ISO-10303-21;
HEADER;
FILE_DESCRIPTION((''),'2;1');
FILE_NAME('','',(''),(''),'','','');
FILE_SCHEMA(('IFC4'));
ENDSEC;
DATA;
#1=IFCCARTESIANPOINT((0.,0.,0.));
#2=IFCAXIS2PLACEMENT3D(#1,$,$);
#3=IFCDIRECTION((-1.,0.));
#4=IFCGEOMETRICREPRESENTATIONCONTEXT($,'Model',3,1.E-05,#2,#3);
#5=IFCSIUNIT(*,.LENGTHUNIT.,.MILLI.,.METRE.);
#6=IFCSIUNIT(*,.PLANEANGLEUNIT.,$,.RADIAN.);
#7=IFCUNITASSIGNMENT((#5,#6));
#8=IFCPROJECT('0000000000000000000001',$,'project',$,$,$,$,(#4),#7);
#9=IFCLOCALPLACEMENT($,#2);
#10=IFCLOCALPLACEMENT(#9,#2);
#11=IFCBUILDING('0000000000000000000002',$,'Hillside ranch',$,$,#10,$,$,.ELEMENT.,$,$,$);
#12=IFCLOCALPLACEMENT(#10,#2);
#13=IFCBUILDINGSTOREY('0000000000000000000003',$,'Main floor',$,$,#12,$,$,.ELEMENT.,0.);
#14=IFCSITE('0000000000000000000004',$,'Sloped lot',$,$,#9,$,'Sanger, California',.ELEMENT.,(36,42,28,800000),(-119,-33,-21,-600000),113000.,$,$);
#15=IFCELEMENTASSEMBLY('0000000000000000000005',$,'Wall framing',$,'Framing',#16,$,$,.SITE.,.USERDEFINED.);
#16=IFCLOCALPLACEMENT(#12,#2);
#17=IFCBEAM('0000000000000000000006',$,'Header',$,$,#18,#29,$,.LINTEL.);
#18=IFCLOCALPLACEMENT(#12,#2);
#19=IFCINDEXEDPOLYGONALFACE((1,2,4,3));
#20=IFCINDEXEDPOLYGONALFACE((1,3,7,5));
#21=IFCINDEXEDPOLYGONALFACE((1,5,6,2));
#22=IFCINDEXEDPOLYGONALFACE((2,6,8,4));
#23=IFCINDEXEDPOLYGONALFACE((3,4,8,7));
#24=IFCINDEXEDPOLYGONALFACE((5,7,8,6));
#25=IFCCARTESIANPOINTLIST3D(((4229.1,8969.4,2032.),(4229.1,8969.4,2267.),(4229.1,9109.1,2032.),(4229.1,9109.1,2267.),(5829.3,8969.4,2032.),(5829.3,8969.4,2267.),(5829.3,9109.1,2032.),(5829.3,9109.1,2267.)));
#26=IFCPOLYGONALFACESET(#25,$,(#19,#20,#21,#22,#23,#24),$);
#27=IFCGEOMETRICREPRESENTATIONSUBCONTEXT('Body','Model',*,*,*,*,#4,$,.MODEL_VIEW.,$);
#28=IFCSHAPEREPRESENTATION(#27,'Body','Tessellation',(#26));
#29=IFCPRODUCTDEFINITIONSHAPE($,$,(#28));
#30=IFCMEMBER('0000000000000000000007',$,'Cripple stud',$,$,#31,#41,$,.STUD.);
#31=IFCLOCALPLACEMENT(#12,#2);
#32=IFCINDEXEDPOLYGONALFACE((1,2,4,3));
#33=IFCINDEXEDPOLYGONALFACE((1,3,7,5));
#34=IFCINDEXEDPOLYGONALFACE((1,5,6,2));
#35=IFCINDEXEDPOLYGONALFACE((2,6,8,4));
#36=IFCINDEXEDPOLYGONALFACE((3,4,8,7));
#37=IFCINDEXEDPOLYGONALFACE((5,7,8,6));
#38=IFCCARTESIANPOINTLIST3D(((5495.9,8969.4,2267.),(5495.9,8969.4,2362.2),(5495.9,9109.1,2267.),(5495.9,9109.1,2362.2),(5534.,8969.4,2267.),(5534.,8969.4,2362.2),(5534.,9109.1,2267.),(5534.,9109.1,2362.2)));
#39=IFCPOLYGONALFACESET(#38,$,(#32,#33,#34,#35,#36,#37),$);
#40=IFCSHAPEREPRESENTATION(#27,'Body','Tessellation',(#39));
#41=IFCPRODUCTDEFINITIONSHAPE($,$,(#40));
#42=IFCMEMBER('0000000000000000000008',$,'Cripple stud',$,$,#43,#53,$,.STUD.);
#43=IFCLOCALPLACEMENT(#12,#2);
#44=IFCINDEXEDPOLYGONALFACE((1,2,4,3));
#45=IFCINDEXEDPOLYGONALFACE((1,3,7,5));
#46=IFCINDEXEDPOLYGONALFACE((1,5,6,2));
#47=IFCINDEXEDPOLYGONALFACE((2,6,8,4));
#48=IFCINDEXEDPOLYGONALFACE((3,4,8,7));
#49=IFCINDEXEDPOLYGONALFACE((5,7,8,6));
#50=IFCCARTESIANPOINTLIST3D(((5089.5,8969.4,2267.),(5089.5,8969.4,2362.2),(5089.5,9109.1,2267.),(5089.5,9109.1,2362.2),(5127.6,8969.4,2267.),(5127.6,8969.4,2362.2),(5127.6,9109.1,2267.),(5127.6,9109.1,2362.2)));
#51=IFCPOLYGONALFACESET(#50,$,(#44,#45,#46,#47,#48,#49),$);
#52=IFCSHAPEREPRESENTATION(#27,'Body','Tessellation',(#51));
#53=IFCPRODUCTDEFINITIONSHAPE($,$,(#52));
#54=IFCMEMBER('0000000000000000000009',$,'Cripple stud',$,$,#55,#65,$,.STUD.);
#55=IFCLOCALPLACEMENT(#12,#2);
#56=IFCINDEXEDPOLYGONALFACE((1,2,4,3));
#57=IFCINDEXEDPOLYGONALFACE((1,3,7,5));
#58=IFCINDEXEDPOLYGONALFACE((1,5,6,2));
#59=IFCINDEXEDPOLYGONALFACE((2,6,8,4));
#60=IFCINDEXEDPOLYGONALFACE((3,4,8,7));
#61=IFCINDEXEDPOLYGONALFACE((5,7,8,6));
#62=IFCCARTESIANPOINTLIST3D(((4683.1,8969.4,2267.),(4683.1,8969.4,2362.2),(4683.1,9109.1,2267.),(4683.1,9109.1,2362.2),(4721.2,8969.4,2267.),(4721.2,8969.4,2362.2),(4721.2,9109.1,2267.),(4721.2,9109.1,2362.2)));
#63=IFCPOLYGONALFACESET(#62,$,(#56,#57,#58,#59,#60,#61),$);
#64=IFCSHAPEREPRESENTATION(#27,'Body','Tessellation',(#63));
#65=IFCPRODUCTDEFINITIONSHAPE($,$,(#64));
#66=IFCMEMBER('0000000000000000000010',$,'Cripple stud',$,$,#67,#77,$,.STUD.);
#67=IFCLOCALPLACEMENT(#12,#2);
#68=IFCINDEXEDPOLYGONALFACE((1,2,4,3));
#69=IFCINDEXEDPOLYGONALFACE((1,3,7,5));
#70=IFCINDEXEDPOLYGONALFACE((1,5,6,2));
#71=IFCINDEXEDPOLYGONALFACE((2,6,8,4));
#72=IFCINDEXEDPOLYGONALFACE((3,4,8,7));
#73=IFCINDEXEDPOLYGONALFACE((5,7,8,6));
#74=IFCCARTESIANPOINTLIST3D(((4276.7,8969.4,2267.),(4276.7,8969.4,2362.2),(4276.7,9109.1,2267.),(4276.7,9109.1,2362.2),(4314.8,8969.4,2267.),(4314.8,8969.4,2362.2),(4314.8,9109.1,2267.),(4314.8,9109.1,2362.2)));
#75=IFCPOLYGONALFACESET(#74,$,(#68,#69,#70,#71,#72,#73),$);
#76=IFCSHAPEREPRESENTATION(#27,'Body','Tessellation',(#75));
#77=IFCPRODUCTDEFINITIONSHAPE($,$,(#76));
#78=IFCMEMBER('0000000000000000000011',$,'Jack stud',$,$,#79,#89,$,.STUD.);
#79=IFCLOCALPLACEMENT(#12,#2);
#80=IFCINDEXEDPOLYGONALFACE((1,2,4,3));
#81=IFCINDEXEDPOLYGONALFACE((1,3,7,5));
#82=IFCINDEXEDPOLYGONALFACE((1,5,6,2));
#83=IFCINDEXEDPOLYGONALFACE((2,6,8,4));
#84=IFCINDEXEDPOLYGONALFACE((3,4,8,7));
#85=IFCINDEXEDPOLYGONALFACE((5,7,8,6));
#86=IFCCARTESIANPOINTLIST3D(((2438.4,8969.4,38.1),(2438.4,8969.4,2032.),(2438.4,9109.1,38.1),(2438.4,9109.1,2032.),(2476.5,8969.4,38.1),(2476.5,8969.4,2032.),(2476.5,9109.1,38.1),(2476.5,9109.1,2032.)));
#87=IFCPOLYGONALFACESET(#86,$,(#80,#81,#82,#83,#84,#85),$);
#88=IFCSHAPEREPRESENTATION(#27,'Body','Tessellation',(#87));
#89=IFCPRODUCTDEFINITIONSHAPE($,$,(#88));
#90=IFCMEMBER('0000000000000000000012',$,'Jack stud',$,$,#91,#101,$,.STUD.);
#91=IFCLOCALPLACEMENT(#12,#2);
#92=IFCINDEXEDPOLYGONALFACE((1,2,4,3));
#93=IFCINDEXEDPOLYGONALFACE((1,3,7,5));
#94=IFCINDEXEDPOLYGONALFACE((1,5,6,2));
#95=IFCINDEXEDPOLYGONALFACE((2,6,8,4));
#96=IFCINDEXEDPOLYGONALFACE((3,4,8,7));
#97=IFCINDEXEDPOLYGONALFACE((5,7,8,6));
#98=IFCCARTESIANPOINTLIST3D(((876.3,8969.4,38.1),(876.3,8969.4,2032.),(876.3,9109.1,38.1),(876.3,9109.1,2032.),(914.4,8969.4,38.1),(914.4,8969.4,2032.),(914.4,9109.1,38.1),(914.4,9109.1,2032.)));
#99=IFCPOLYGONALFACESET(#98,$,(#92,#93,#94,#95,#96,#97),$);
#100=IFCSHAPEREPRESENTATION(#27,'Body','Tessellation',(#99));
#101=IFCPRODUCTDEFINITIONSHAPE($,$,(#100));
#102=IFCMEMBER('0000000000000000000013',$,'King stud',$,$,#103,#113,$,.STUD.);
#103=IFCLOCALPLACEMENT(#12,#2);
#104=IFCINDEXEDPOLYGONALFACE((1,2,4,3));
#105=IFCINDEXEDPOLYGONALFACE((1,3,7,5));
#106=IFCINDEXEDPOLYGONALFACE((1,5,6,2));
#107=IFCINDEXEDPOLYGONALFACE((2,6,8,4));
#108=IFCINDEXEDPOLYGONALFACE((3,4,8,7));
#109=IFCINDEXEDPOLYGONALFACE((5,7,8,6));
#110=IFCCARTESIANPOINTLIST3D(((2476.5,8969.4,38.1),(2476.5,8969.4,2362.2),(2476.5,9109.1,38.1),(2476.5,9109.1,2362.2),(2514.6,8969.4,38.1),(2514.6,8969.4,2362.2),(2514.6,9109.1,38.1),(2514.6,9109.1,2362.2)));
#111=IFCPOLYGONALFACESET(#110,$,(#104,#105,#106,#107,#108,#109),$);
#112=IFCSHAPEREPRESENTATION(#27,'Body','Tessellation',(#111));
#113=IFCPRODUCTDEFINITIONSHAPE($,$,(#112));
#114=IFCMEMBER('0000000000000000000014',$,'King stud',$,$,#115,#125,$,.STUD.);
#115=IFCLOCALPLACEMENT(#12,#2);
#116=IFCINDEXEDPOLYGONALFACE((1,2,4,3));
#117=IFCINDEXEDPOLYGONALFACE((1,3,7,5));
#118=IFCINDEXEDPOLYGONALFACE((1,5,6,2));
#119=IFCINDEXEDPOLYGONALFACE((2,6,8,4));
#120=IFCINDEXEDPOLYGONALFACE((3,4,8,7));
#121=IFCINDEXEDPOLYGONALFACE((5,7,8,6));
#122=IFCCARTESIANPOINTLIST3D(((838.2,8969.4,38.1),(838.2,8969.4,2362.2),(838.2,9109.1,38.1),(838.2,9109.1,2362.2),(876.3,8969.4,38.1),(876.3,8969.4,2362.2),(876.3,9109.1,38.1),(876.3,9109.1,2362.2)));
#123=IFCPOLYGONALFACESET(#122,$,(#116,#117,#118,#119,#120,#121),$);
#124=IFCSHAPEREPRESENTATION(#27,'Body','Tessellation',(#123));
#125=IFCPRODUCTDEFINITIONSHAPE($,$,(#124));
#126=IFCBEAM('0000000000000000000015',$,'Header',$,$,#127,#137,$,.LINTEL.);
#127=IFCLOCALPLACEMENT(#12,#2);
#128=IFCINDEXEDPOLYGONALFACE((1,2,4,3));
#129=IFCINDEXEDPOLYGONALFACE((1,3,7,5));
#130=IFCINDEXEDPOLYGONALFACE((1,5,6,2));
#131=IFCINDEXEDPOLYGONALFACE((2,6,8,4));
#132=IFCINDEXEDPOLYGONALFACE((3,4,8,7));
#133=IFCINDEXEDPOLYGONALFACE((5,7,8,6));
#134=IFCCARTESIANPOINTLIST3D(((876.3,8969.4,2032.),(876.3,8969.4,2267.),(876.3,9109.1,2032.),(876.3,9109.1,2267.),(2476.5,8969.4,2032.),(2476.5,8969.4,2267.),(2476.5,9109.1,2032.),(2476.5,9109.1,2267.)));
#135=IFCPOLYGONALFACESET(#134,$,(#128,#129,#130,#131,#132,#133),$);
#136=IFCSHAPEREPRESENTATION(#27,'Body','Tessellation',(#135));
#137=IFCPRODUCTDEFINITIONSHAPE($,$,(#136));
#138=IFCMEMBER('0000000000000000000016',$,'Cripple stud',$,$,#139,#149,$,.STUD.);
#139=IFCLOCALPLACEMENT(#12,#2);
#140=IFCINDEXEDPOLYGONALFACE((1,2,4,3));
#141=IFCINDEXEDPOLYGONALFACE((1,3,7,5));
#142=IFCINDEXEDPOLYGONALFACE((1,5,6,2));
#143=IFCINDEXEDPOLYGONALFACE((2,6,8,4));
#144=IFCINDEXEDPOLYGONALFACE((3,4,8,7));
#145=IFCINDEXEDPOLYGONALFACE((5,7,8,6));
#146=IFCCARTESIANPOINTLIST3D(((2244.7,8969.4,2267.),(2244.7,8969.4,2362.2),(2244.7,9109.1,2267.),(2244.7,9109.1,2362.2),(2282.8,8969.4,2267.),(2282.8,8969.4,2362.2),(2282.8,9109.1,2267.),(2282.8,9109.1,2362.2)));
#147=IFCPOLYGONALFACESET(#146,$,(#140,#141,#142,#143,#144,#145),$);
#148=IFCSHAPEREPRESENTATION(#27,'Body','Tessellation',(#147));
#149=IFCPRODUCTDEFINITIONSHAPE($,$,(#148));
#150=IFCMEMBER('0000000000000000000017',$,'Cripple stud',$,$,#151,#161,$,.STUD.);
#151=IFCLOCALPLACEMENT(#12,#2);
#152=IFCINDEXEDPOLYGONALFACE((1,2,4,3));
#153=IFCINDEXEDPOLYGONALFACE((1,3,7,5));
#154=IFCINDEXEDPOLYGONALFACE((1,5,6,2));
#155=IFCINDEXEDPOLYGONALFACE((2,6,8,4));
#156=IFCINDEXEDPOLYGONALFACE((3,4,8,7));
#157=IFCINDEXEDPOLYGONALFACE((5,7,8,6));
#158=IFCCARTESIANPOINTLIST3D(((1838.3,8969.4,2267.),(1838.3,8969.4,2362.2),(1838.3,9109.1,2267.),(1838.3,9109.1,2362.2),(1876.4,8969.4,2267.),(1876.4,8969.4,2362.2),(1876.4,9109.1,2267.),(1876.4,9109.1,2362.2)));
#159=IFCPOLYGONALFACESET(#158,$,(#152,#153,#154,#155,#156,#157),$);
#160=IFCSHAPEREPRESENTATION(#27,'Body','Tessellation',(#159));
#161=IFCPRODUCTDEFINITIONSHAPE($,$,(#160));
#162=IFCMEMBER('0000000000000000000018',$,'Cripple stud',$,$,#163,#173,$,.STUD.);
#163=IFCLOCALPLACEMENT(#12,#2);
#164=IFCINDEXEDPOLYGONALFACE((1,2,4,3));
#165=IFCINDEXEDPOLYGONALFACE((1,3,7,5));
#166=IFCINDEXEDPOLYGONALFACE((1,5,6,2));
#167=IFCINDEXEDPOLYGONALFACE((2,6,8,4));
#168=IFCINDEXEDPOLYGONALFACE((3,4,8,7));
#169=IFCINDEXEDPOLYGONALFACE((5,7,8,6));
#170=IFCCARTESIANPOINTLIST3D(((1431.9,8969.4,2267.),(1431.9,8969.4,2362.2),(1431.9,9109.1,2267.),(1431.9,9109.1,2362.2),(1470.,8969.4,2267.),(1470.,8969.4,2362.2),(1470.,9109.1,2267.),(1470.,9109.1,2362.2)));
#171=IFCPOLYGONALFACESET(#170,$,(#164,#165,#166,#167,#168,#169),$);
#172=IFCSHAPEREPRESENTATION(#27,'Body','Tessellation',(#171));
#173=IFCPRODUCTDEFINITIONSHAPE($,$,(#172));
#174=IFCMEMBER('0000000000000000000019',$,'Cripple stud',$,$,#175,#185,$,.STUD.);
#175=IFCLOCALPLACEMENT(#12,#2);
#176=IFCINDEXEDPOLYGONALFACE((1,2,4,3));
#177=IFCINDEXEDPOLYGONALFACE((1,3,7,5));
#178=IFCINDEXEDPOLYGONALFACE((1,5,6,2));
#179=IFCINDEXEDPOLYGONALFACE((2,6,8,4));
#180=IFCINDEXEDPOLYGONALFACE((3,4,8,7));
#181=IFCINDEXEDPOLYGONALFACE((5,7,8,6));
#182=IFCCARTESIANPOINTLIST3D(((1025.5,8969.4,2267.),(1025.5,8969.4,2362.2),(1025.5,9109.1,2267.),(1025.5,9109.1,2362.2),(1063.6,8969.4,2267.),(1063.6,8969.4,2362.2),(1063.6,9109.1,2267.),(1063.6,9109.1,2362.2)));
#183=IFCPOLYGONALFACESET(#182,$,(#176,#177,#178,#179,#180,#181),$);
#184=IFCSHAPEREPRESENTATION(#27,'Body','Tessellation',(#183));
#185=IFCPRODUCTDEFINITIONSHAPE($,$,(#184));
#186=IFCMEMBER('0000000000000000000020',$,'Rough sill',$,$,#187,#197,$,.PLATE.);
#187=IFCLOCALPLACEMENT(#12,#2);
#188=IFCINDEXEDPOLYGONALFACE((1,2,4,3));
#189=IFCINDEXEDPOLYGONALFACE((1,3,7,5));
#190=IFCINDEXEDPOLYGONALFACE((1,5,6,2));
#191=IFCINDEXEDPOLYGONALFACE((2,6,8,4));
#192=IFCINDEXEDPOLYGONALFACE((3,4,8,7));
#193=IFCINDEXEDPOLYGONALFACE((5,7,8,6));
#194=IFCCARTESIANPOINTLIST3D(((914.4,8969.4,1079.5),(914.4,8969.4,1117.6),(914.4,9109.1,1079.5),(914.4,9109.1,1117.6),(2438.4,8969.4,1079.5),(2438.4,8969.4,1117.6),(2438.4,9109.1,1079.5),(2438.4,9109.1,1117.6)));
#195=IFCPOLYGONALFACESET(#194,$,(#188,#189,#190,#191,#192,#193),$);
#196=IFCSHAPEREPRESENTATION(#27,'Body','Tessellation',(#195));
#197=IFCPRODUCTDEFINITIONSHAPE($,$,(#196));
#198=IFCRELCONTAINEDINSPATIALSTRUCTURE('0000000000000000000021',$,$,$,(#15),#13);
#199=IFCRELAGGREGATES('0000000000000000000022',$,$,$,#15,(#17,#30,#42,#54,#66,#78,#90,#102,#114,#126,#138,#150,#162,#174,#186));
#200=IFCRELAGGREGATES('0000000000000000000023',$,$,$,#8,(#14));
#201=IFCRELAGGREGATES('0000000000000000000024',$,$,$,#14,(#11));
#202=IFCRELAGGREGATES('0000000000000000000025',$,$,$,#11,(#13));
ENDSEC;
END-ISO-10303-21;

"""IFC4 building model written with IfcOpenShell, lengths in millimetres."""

from ifc_helpers import new_model, si_unit, direction, frame, origin, origin_with_axes, place, context, subcontext, project, spatial, polyline, outline, extrude, element, aggregate, save


model = new_model("IFC4")

# Units and contexts
model_context = context("Model", 3, precision=1e-05, world=origin(), true_north=direction((-1.0, 0.0)))
body_context = subcontext(model_context, "Body", "Model", "MODEL_VIEW")
ifc_project = project(units=[si_unit("LENGTHUNIT", "METRE", prefix="MILLI"), si_unit("PLANEANGLEUNIT", "RADIAN")], contexts=[model_context])

# Site, building, storey
site_placement = place(None, origin())
site = spatial("IfcSite", under=ifc_project, at=site_placement, Name="Sloped lot", LongName="Sanger, California", CompositionType="ELEMENT", RefLatitude=(36, 42, 28, 800000), RefLongitude=(-119, -33, -21, -600000), RefElevation=113000.0)
building_placement = place(site_placement, origin())
building = spatial("IfcBuilding", under=site, at=building_placement, Name="Hillside ranch", CompositionType="ELEMENT")
storey_placement = place(building_placement, origin())
storey = spatial("IfcBuildingStorey", under=building, at=storey_placement, Name="Main floor", CompositionType="ELEMENT", Elevation=0.0)

# Element assembly, beams, members
assembly_placement = place(storey_placement, origin_with_axes())
assembly = element("IfcElementAssembly", 1, at=assembly_placement, inside=storey, Name="Wall framing", ObjectType="Framing", AssemblyPlace="SITE", PredefinedType="USERDEFINED")
beam_1_placement = place(storey_placement, origin_with_axes())
beam_1 = element("IfcBeam", 2, at=beam_1_placement, Name="Header", PredefinedType="LINTEL", context=body_context, shape_type="SweptSolid", body=[
    extrude(outline(polyline([(0.0, 0.0), (1600.2, 0.0), (1600.2, 139.7), (0.0, 139.7), (0.0, 0.0)])), frame((5829.3, 9109.1, 2032.0), z_axis=(0.0, 0.0, 1.0), x_axis=(-1.0, 0.0, 0.0)), (0.0, 0.0, 1.0), 234.9),
])
member_1_placement = place(storey_placement, origin_with_axes())
member_1 = element("IfcMember", 3, at=member_1_placement, Name="Cripple stud", PredefinedType="STUD", context=body_context, shape_type="SweptSolid", body=[
    extrude(outline(polyline([(0.0, 0.0), (38.1, 0.0), (38.1, 139.7), (0.0, 139.7), (0.0, 0.0)])), frame((5534.0, 9109.1, 2266.9), z_axis=(0.0, 0.0, 1.0), x_axis=(-1.0, 0.0, 0.0)), (0.0, 0.0, 1.0), 95.2),
])
member_2_placement = place(storey_placement, origin_with_axes())
member_2 = element("IfcMember", 4, at=member_2_placement, Name="Cripple stud", PredefinedType="STUD", context=body_context, shape_type="SweptSolid", body=[
    extrude(outline(polyline([(0.0, 0.0), (38.1, 0.0), (38.1, 139.7), (0.0, 139.7), (0.0, 0.0)])), frame((5127.6, 9109.1, 2266.9), z_axis=(0.0, 0.0, 1.0), x_axis=(-1.0, 0.0, 0.0)), (0.0, 0.0, 1.0), 95.2),
])
member_3_placement = place(storey_placement, origin_with_axes())
member_3 = element("IfcMember", 5, at=member_3_placement, Name="Cripple stud", PredefinedType="STUD", context=body_context, shape_type="SweptSolid", body=[
    extrude(outline(polyline([(0.0, 0.0), (38.1, 0.0), (38.1, 139.7), (0.0, 139.7), (0.0, 0.0)])), frame((4721.2, 9109.1, 2266.9), z_axis=(0.0, 0.0, 1.0), x_axis=(-1.0, 0.0, 0.0)), (0.0, 0.0, 1.0), 95.2),
])
member_4_placement = place(storey_placement, origin_with_axes())
member_4 = element("IfcMember", 6, at=member_4_placement, Name="Cripple stud", PredefinedType="STUD", context=body_context, shape_type="SweptSolid", body=[
    extrude(outline(polyline([(0.0, 0.0), (38.1, 0.0), (38.1, 139.7), (0.0, 139.7), (0.0, 0.0)])), frame((4314.8, 9109.1, 2266.9), z_axis=(0.0, 0.0, 1.0), x_axis=(-1.0, 0.0, 0.0)), (0.0, 0.0, 1.0), 95.2),
])
member_5_placement = place(storey_placement, origin_with_axes())
member_5 = element("IfcMember", 7, at=member_5_placement, Name="Jack stud", PredefinedType="STUD", context=body_context, shape_type="SweptSolid", body=[
    extrude(outline(polyline([(0.0, 0.0), (38.1, 0.0), (38.1, 139.7), (0.0, 139.7), (0.0, 0.0)])), frame((2476.5, 9109.1, 38.1), z_axis=(0.0, 0.0, 1.0), x_axis=(-1.0, 0.0, 0.0)), (0.0, 0.0, 1.0), 1993.9),
])
member_6_placement = place(storey_placement, origin_with_axes())
member_6 = element("IfcMember", 8, at=member_6_placement, Name="Jack stud", PredefinedType="STUD", context=body_context, shape_type="SweptSolid", body=[
    extrude(outline(polyline([(0.0, 0.0), (38.1, 0.0), (38.1, 139.7), (0.0, 139.7), (0.0, 0.0)])), frame((914.4, 9109.1, 38.1), z_axis=(0.0, 0.0, 1.0), x_axis=(-1.0, 0.0, 0.0)), (0.0, 0.0, 1.0), 1993.9),
])
member_7_placement = place(storey_placement, origin_with_axes())
member_7 = element("IfcMember", 9, at=member_7_placement, Name="King stud", PredefinedType="STUD", context=body_context, shape_type="SweptSolid", body=[
    extrude(outline(polyline([(0.0, 0.0), (38.1, 0.0), (38.1, 139.7), (0.0, 139.7), (0.0, 0.0)])), frame((2514.6, 9109.1, 38.1), z_axis=(0.0, 0.0, 1.0), x_axis=(-1.0, 0.0, 0.0)), (0.0, 0.0, 1.0), 2324.1),
])
member_8_placement = place(storey_placement, origin_with_axes())
member_8 = element("IfcMember", 10, at=member_8_placement, Name="King stud", PredefinedType="STUD", context=body_context, shape_type="SweptSolid", body=[
    extrude(outline(polyline([(0.0, 0.0), (38.1, 0.0), (38.1, 139.7), (0.0, 139.7), (0.0, 0.0)])), frame((876.3, 9109.1, 38.1), z_axis=(0.0, 0.0, 1.0), x_axis=(-1.0, 0.0, 0.0)), (0.0, 0.0, 1.0), 2324.1),
])
beam_2_placement = place(storey_placement, origin_with_axes())
beam_2 = element("IfcBeam", 11, at=beam_2_placement, Name="Header", PredefinedType="LINTEL", context=body_context, shape_type="SweptSolid", body=[
    extrude(outline(polyline([(0.0, 0.0), (1600.2, 0.0), (1600.2, 139.7), (0.0, 139.7), (0.0, 0.0)])), frame((2476.5, 9109.1, 2032.0), z_axis=(0.0, 0.0, 1.0), x_axis=(-1.0, 0.0, 0.0)), (0.0, 0.0, 1.0), 234.9),
])
member_9_placement = place(storey_placement, origin_with_axes())
member_9 = element("IfcMember", 12, at=member_9_placement, Name="Cripple stud", PredefinedType="STUD", context=body_context, shape_type="SweptSolid", body=[
    extrude(outline(polyline([(0.0, 0.0), (38.1, 0.0), (38.1, 139.7), (0.0, 139.7), (0.0, 0.0)])), frame((2282.8, 9109.1, 2266.9), z_axis=(0.0, 0.0, 1.0), x_axis=(-1.0, 0.0, 0.0)), (0.0, 0.0, 1.0), 95.2),
])
member_10_placement = place(storey_placement, origin_with_axes())
member_10 = element("IfcMember", 13, at=member_10_placement, Name="Cripple stud", PredefinedType="STUD", context=body_context, shape_type="SweptSolid", body=[
    extrude(outline(polyline([(0.0, 0.0), (38.1, 0.0), (38.1, 139.7), (0.0, 139.7), (0.0, 0.0)])), frame((1876.4, 9109.1, 2266.9), z_axis=(0.0, 0.0, 1.0), x_axis=(-1.0, 0.0, 0.0)), (0.0, 0.0, 1.0), 95.2),
])
member_11_placement = place(storey_placement, origin_with_axes())
member_11 = element("IfcMember", 14, at=member_11_placement, Name="Cripple stud", PredefinedType="STUD", context=body_context, shape_type="SweptSolid", body=[
    extrude(outline(polyline([(0.0, 0.0), (38.1, 0.0), (38.1, 139.7), (0.0, 139.7), (0.0, 0.0)])), frame((1470.0, 9109.1, 2266.9), z_axis=(0.0, 0.0, 1.0), x_axis=(-1.0, 0.0, 0.0)), (0.0, 0.0, 1.0), 95.2),
])
member_12_placement = place(storey_placement, origin_with_axes())
member_12 = element("IfcMember", 15, at=member_12_placement, Name="Cripple stud", PredefinedType="STUD", context=body_context, shape_type="SweptSolid", body=[
    extrude(outline(polyline([(0.0, 0.0), (38.1, 0.0), (38.1, 139.7), (0.0, 139.7), (0.0, 0.0)])), frame((1063.6, 9109.1, 2266.9), z_axis=(0.0, 0.0, 1.0), x_axis=(-1.0, 0.0, 0.0)), (0.0, 0.0, 1.0), 95.2),
])
member_13_placement = place(storey_placement, origin_with_axes())
member_13 = element("IfcMember", 16, at=member_13_placement, Name="Rough sill", PredefinedType="PLATE", context=body_context, shape_type="SweptSolid", body=[
    extrude(outline(polyline([(0.0, 0.0), (1524.0, 0.0), (1524.0, 139.7), (0.0, 139.7), (0.0, 0.0)])), frame((2438.4, 9109.1, 1079.5), z_axis=(0.0, 0.0, 1.0), x_axis=(-1.0, 0.0, 0.0)), (0.0, 0.0, 1.0), 38.1),
])
aggregate(assembly, [beam_1, member_1, member_2, member_3, member_4, member_5, member_6, member_7, member_8, beam_2, member_9, member_10, member_11, member_12, member_13])

save(model, "model.ifc")
